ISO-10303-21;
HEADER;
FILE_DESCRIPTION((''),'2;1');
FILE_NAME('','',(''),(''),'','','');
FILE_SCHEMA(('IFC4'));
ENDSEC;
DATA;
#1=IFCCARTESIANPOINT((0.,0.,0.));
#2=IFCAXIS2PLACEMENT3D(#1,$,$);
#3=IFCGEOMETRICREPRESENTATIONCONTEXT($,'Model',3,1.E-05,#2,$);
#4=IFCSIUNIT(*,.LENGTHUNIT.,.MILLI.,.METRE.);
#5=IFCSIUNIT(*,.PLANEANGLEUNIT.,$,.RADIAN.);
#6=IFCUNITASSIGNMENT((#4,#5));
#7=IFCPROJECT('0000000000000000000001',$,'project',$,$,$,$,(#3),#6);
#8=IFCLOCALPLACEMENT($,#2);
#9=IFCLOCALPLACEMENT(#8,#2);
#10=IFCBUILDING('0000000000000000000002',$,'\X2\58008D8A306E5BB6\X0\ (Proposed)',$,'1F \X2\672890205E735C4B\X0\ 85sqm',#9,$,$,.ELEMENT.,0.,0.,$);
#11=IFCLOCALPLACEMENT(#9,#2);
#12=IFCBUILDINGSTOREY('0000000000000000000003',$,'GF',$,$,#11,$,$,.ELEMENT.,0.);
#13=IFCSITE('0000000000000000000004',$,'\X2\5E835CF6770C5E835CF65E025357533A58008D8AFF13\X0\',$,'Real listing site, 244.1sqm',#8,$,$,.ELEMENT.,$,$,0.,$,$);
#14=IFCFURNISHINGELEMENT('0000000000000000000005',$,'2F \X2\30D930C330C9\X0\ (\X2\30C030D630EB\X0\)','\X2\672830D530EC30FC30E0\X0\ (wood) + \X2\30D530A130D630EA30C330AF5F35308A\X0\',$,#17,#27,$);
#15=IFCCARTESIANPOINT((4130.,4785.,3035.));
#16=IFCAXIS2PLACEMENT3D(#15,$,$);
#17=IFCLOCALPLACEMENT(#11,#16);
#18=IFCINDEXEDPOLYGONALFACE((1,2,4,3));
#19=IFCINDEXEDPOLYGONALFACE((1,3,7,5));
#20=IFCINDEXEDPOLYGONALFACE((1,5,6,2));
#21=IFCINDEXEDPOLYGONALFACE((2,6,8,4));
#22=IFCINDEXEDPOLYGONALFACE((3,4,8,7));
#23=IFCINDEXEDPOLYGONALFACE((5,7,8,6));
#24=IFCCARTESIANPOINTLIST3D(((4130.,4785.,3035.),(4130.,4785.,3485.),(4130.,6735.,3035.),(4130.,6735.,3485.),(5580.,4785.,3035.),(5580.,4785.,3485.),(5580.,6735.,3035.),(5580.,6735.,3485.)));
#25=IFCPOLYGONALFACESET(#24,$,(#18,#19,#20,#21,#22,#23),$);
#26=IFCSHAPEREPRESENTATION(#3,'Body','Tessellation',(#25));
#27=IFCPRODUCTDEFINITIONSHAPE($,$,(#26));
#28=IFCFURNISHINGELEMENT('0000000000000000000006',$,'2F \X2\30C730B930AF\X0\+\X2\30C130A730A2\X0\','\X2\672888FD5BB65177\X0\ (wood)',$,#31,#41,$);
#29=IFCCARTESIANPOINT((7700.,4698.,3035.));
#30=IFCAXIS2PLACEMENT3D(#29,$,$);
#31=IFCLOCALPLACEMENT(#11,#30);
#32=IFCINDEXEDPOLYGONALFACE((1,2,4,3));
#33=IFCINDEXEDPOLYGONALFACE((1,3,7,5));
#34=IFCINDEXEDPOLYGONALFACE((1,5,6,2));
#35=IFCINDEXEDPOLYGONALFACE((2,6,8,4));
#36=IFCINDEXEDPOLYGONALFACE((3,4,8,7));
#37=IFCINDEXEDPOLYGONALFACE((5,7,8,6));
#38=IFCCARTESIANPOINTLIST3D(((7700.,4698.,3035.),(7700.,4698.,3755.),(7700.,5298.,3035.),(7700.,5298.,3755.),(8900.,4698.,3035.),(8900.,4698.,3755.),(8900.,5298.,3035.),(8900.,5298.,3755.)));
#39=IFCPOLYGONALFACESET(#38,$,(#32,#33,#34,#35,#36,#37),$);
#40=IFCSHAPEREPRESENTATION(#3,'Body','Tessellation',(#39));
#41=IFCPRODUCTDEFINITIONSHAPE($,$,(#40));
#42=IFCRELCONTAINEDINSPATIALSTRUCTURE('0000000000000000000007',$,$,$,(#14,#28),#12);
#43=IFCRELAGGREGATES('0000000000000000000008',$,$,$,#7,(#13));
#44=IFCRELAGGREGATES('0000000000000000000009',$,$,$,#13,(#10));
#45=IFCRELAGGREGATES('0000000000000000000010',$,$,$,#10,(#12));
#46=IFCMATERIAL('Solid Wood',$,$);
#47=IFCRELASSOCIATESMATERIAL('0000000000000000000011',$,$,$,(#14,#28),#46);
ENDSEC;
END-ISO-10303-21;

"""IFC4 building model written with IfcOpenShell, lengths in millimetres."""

from ifc_helpers import new_model, si_unit, frame, frame_2d, origin, place, context, project, spatial, rectangle, extrude, material, element, save


model = new_model("IFC4")

# Units and contexts
model_context = context("Model", 3, precision=1e-05, world=origin())
ifc_project = project(units=[si_unit("LENGTHUNIT", "METRE", prefix="MILLI"), si_unit("PLANEANGLEUNIT", "RADIAN")], contexts=[model_context])

# Site, building, storey
site_placement = place(None, origin())
site = spatial("IfcSite", under=ifc_project, at=site_placement, Name="広島県広島市南区堀越３", ObjectType="Real listing site, 244.1sqm", CompositionType="ELEMENT", RefElevation=0.0)
building_placement = place(site_placement, origin())
building = spatial("IfcBuilding", under=site, at=building_placement, Name="堀越の家 (Proposed)", ObjectType="1F 木造平屋 85sqm", CompositionType="ELEMENT", ElevationOfRefHeight=0.0, ElevationOfTerrain=0.0)
storey_placement = place(building_placement, origin())
storey = spatial("IfcBuildingStorey", under=building, at=storey_placement, Name="GF", CompositionType="ELEMENT", Elevation=0.0)

# Shared definitions
ifc_material_1 = material(Name="Solid Wood")

# Furnishing elements
furnishing_1_placement = place(storey_placement, frame((4130.0, 4785.0, 3035.0)))
element("IfcFurnishingElement", 1, at=furnishing_1_placement, inside=storey, material=ifc_material_1, Name="2F ベッド (ダブル)", Description="木フレーム (wood) + ファブリック張り", context=model_context, shape_type="SweptSolid", body=[
    extrude(rectangle(XDim=1450.0, YDim=1950.0, at=frame_2d((725.0, 975.0))), frame((4130.0, 4785.0, 3035.0)), (0.0, 0.0, 1.0), 450.0),
])
furnishing_2_placement = place(storey_placement, frame((7700.0, 4698.0, 3035.0)))
element("IfcFurnishingElement", 2, at=furnishing_2_placement, inside=storey, material=ifc_material_1, Name="2F デスク+チェア", Description="木製家具 (wood)", context=model_context, shape_type="SweptSolid", body=[
    extrude(rectangle(XDim=1200.0, YDim=600.0, at=frame_2d((600.0, 300.0))), frame((7700.0, 4698.0, 3035.0)), (0.0, 0.0, 1.0), 720.0),
])

save(model, "model.ifc")
